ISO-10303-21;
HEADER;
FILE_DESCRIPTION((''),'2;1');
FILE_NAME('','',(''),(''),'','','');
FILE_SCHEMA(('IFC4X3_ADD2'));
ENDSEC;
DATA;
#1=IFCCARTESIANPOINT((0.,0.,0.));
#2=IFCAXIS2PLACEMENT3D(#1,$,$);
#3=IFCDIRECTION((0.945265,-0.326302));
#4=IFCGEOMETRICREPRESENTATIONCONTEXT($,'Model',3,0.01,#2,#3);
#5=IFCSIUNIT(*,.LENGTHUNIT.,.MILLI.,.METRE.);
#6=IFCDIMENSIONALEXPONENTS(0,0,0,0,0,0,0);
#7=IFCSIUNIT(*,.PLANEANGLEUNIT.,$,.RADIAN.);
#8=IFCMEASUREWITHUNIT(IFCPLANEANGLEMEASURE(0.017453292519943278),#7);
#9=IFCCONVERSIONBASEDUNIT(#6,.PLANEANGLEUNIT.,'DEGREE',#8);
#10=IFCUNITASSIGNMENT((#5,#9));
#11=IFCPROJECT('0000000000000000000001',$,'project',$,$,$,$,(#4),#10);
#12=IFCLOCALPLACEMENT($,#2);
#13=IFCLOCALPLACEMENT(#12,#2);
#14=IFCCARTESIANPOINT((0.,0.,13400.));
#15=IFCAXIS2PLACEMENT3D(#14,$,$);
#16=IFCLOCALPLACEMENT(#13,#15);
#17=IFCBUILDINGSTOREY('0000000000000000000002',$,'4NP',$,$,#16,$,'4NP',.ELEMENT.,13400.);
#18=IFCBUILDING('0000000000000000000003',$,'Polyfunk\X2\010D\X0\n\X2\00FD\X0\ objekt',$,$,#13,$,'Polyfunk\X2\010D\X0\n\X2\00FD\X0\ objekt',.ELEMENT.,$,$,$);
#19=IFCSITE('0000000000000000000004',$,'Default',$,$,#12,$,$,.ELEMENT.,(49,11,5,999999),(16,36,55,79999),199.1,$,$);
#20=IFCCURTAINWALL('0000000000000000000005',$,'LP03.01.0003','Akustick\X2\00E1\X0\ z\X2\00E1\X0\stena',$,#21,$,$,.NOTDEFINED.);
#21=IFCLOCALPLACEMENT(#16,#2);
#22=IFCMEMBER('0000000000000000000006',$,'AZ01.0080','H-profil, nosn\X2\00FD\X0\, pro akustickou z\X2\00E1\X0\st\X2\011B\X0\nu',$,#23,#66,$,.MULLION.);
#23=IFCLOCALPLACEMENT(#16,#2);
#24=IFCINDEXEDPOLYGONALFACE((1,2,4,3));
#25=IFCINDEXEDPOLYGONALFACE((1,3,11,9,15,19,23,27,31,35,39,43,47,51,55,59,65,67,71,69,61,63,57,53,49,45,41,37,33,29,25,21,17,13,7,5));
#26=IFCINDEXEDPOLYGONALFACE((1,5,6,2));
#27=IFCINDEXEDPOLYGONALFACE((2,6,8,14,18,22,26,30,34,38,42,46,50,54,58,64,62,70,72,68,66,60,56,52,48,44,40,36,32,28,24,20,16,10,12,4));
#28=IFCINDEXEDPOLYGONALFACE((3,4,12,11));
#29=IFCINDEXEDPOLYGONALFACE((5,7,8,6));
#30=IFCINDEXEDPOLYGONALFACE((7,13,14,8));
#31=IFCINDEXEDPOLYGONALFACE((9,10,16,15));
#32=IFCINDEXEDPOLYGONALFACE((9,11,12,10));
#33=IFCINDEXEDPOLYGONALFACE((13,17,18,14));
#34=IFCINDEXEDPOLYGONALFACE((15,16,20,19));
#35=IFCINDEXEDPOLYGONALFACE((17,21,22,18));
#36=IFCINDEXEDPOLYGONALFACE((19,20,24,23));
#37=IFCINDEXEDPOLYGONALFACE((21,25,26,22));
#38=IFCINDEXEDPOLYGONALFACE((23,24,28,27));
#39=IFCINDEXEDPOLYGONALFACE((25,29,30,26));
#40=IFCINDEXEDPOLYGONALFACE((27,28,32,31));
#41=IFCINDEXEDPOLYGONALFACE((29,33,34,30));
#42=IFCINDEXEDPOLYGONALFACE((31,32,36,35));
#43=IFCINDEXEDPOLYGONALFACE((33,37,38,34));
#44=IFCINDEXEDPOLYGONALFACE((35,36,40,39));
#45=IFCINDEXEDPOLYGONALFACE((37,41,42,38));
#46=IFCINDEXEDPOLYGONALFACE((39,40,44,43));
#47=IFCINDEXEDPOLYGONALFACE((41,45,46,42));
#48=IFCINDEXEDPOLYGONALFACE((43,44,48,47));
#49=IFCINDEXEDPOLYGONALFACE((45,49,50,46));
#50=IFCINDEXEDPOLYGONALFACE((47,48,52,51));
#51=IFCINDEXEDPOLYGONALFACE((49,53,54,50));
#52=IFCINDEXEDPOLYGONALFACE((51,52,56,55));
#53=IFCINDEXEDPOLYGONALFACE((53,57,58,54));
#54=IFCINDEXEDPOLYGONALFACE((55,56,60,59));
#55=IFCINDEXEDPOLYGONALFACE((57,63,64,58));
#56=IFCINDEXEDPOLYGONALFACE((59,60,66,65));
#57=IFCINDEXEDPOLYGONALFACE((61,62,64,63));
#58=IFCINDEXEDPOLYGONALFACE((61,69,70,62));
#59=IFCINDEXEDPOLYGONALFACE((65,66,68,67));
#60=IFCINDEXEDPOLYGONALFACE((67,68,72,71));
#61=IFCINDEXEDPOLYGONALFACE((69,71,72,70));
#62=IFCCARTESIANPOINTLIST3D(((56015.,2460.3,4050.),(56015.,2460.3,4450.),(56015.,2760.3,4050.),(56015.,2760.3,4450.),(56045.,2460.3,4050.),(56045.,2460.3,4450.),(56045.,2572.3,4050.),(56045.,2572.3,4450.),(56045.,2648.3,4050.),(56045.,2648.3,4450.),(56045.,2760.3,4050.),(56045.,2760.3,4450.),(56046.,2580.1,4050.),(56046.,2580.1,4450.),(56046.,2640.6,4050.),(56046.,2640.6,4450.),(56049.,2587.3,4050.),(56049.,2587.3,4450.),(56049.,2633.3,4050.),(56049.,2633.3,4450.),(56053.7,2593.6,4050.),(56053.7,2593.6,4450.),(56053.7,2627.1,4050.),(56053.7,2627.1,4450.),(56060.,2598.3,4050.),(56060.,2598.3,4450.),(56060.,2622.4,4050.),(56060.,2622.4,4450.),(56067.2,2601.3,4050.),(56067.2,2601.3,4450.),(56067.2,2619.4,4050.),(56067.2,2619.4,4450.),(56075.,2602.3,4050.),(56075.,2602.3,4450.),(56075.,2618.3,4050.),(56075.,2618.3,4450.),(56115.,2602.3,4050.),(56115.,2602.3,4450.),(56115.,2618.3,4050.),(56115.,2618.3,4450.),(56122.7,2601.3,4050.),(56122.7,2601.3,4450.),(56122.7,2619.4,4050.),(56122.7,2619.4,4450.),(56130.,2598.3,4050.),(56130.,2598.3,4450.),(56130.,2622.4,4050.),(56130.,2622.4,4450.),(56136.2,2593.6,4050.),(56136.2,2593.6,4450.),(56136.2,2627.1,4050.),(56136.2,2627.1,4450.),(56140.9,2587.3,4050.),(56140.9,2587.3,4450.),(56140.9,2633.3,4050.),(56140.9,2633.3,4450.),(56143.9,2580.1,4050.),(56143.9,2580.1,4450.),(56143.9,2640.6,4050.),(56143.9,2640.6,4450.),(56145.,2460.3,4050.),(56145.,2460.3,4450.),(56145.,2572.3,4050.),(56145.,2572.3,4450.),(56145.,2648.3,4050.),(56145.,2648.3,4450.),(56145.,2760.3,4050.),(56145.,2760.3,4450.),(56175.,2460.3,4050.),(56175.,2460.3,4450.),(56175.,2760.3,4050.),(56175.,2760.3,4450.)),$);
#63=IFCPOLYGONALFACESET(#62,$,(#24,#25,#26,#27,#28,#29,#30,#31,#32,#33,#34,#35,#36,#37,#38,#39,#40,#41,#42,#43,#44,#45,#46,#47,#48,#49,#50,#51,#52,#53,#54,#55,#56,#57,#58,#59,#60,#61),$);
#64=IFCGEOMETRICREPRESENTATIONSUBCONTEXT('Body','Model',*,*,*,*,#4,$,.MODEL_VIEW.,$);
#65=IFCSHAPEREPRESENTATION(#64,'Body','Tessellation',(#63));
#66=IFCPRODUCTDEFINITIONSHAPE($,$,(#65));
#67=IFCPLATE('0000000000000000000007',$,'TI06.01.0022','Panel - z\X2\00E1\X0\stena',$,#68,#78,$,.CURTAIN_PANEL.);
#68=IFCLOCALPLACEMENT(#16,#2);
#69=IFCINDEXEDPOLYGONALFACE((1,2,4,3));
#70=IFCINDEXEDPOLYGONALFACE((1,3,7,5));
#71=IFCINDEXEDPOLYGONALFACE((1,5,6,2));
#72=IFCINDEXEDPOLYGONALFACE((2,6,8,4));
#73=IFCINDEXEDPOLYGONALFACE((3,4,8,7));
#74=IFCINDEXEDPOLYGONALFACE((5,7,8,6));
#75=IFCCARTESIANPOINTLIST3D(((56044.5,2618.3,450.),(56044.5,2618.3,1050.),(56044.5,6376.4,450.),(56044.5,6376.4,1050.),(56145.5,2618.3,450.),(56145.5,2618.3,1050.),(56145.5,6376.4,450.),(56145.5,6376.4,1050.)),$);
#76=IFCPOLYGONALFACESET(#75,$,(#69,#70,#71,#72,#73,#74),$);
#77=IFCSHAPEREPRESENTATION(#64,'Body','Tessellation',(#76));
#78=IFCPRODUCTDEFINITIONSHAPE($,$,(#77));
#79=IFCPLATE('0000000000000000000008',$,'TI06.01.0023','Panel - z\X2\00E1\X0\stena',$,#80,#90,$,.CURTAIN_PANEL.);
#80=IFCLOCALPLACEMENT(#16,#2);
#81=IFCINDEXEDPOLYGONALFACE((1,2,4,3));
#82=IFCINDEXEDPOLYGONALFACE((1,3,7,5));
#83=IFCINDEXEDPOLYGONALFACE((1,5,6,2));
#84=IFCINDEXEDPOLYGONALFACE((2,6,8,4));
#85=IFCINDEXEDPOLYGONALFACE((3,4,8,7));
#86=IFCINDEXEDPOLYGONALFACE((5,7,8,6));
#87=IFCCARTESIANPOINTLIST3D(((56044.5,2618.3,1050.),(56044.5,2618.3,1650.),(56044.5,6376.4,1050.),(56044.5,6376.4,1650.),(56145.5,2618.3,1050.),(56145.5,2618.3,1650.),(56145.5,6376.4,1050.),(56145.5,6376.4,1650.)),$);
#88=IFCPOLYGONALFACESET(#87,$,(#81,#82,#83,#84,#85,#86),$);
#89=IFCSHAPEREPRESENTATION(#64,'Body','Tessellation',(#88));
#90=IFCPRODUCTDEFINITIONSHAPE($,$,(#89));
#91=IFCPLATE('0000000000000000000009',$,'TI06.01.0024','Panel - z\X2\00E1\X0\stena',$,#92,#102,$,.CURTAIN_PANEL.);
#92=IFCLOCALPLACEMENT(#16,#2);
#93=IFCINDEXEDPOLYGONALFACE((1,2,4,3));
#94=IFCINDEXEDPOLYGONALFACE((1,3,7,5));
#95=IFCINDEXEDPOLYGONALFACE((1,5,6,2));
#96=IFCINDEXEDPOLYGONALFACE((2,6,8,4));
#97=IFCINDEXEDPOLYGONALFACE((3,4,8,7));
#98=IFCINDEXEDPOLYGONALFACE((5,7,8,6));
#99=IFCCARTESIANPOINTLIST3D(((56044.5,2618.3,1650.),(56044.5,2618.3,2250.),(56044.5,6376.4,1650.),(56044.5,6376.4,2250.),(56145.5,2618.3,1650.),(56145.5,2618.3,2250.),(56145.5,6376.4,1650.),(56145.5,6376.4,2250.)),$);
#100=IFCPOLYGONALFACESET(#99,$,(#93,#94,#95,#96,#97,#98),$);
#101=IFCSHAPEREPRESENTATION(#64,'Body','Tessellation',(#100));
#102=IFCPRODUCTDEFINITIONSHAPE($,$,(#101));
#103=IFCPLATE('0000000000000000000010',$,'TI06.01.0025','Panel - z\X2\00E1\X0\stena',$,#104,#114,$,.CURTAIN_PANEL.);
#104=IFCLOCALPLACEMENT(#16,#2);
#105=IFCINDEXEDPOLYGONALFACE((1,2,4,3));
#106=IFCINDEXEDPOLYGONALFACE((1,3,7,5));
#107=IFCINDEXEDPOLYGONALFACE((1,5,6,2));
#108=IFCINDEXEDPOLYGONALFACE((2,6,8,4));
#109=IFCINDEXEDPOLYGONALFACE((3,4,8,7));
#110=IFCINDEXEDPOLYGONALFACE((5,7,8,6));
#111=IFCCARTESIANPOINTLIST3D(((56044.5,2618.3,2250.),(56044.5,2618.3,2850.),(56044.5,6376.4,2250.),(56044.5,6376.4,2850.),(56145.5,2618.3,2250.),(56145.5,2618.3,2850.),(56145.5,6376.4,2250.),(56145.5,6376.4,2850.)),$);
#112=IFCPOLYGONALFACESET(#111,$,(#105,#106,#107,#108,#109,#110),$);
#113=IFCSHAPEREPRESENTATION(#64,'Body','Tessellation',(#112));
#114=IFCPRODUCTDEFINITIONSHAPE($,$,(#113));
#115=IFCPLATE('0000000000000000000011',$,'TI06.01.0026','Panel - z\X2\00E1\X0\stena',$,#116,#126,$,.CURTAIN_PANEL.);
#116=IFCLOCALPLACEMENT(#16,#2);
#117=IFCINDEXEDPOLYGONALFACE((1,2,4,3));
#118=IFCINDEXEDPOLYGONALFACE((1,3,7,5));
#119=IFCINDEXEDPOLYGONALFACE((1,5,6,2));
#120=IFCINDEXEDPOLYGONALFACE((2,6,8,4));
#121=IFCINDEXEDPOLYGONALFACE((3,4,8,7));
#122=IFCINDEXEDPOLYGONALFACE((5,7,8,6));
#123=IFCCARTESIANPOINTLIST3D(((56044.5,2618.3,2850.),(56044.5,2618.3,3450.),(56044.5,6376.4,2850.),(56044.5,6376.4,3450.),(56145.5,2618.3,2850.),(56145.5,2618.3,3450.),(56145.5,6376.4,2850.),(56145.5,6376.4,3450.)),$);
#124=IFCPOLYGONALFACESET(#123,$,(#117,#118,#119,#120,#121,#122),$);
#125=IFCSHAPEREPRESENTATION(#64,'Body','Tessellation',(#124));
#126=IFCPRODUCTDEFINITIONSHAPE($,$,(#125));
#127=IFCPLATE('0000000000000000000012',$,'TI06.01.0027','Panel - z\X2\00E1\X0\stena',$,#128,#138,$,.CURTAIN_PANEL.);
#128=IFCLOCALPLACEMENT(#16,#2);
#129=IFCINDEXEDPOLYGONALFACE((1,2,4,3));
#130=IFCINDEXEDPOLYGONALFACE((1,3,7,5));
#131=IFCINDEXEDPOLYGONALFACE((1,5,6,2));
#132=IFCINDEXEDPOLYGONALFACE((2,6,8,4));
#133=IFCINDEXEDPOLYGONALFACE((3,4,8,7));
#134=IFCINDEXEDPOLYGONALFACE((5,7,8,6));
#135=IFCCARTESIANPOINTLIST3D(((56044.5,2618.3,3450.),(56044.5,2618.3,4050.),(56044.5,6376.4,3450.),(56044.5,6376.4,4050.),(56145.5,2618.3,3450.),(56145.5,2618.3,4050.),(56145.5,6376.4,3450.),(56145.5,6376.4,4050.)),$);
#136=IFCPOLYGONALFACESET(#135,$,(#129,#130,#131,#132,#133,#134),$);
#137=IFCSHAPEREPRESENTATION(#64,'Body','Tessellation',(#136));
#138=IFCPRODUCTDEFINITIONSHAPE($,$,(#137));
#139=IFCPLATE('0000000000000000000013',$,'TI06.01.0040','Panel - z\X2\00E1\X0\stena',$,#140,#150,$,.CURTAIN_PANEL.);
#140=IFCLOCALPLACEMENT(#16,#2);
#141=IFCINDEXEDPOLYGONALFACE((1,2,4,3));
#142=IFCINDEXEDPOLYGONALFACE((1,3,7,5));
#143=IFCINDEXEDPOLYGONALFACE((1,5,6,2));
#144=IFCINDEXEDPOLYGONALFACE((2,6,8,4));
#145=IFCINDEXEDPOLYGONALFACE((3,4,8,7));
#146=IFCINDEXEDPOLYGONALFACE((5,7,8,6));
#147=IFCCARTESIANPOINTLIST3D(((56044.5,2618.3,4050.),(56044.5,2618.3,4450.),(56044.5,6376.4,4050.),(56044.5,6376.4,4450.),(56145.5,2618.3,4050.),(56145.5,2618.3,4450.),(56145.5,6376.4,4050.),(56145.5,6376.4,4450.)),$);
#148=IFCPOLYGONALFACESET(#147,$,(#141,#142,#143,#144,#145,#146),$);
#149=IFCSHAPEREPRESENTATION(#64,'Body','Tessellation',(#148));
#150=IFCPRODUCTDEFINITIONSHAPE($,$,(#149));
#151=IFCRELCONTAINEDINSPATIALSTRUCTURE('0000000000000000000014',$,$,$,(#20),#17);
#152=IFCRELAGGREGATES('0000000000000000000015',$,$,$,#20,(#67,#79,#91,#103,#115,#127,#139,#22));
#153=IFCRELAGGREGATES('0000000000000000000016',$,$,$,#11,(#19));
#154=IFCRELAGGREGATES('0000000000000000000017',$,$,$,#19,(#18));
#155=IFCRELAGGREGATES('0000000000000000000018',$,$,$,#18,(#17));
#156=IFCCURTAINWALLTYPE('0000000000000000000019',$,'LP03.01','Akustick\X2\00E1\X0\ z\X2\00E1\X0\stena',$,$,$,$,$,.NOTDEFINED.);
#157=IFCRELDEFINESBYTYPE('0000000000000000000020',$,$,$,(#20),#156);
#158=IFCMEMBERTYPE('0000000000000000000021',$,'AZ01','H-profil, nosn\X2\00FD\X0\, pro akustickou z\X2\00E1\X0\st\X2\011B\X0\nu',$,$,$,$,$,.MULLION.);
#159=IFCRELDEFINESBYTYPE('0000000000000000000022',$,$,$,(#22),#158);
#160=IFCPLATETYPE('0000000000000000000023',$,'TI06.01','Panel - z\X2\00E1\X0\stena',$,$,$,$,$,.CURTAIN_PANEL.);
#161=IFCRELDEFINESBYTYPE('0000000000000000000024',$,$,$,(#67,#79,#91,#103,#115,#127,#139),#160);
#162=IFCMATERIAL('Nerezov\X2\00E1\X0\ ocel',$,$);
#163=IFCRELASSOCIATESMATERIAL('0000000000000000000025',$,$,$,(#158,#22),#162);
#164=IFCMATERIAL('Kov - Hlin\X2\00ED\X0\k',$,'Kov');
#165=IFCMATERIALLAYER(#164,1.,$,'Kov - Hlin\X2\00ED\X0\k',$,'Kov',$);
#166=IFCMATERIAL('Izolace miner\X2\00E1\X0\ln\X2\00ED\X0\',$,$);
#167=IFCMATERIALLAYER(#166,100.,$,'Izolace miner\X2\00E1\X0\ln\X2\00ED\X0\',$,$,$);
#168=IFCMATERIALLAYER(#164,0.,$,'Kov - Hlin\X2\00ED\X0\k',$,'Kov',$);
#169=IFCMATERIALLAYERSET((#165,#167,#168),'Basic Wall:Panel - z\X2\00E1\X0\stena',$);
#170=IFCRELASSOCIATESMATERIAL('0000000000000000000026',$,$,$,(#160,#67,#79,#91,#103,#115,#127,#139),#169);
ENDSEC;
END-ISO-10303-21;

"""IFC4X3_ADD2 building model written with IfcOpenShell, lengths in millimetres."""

from ifc_helpers import new_model, entity, si_unit, converted_unit, direction, frame, frame_2d, origin, place, context, subcontext, project, spatial, polyline, circle_curve, parameter, trimmed, segment, composite_curve, rectangle, outline, extrude, source, transform, mapped, material, layer, layer_set, layer_usage, material_profile, profile_set, profile_usage, type_object, element, aggregate, save


model = new_model("IFC4X3_ADD2")

# Units and contexts
model_context = context("Model", 3, precision=0.01, world=origin(), true_north=direction((0.945265, -0.326302)))
body_context = subcontext(model_context, "Body", "Model", "MODEL_VIEW")
ifc_project = project(units=[si_unit("LENGTHUNIT", "METRE", prefix="MILLI"), converted_unit("PLANEANGLEUNIT", "DEGREE", entity("IfcPlaneAngleMeasure", 0.017453292519943278), si_unit("PLANEANGLEUNIT", "RADIAN"), dimensions=[0, 0, 0, 0, 0, 0, 0])], contexts=[model_context])

# Site, building, storey
site_placement = place(None, origin())
site = spatial("IfcSite", under=ifc_project, at=site_placement, Name="Default", CompositionType="ELEMENT", RefLatitude=(49, 11, 5, 999999), RefLongitude=(16, 36, 55, 79999), RefElevation=199.1)
building_placement = place(site_placement, origin())
building = spatial("IfcBuilding", under=site, at=building_placement, Name="Polyfunkčný objekt", LongName="Polyfunkčný objekt", CompositionType="ELEMENT")
storey_placement = place(building_placement, frame((0.0, 0.0, 13400.0)))
storey = spatial("IfcBuildingStorey", under=building, at=storey_placement, Name="4NP", LongName="4NP", CompositionType="ELEMENT", Elevation=13400.0)

# Shared definitions
curtain_wall_type = type_object("IfcCurtainWallType", Name="LP03.01", Description="Akustická zástena", PredefinedType="NOTDEFINED")
ifc_material_1 = material(Name="Nerezová ocel")
ifc_material_profile = material_profile(ifc_material_1, outline(composite_curve([segment(polyline([(50.0, -150.0), (80.0, -150.0)]), True, "CONTINUOUS"), segment(polyline([(80.0, -150.0), (80.0, 150.0)]), True, "CONTINUOUS"), segment(polyline([(80.0, 150.0), (50.0, 150.0)]), True, "CONTINUOUS"), segment(polyline([(50.0, 150.0), (50.0, 38.0)]), True, "CONTINUOUS"), segment(trimmed(circle_curve(frame_2d((20.0, 38.0), x_axis=(0.0, 1.0)), 30.0), [parameter(180.0)], [parameter(270.0)], True, "PARAMETER"), False, "CONTINUOUS"), segment(polyline([(20.0, 8.0), (-20.0, 8.0)]), True, "CONTINUOUS"), segment(trimmed(circle_curve(frame_2d((-20.0, 38.0), x_axis=(0.0, 1.0)), 30.0), [parameter(90.0)], [parameter(180.0)], True, "PARAMETER"), False, "CONTINUOUS"), segment(polyline([(-50.0, 38.0), (-50.0, 150.0)]), True, "CONTINUOUS"), segment(polyline([(-50.0, 150.0), (-80.0, 150.0)]), True, "CONTINUOUS"), segment(polyline([(-80.0, 150.0), (-80.0, -150.0)]), True, "CONTINUOUS"), segment(polyline([(-80.0, -150.0), (-50.0, -150.0)]), True, "CONTINUOUS"), segment(polyline([(-50.0, -150.0), (-50.0, -38.0)]), True, "CONTINUOUS"), segment(trimmed(circle_curve(frame_2d((-20.0, -38.0), x_axis=(0.0, 1.0)), 30.0), [parameter(0.0)], [parameter(90.0)], True, "PARAMETER"), False, "CONTINUOUS"), segment(polyline([(-20.0, -8.0), (20.0, -8.0)]), True, "CONTINUOUS"), segment(trimmed(circle_curve(frame_2d((20.0, -38.0), x_axis=(0.0, 1.0)), 30.0), [parameter(270.0)], [parameter(0.0)], True, "PARAMETER"), False, "CONTINUOUS"), segment(polyline([(50.0, -38.0), (50.0, -150.0)]), True, "CONTINUOUS")], self_intersect=False)), Name="Profil zástena")
ifc_profile_set = profile_set([ifc_material_profile], Name="Profil zástena")
ifc_profile_usage = profile_usage(ifc_profile_set)
member_type = type_object("IfcMemberType", Name="AZ01", Description="H-profil, nosný, pro akustickou zástěnu", PredefinedType="MULLION", material=ifc_profile_set)

# Curtain wall, member, plates
curtain_wall_1_placement = place(storey_placement, frame((0.0, 0.0, -13400.0)))
curtain_wall_1 = element("IfcCurtainWall", 1, at=curtain_wall_1_placement, inside=storey, type_object=curtain_wall_type, Name="LP03.01.0003", Description="Akustická zástena", PredefinedType="NOTDEFINED")
shared_shape_1 = source(origin(), body_context, "Body", "SweptSolid", [
    extrude(outline(composite_curve([segment(polyline([(-150.0, -50.0), (-150.0, -80.0)]), True, "CONTINUOUS"), segment(polyline([(-150.0, -80.0), (150.0, -80.0)]), True, "CONTINUOUS"), segment(polyline([(150.0, -80.0), (150.0, -50.0)]), True, "CONTINUOUS"), segment(polyline([(150.0, -50.0), (38.0, -50.0)]), True, "CONTINUOUS"), segment(trimmed(circle_curve(frame_2d((38.0, -20.0), x_axis=(1.0, 0.0)), 30.0), [parameter(180.0)], [parameter(270.0)], True, "PARAMETER"), False, "CONTINUOUS"), segment(polyline([(8.0, -20.0), (8.0, 20.0)]), True, "CONTINUOUS"), segment(trimmed(circle_curve(frame_2d((38.0, 20.0), x_axis=(1.0, 0.0)), 30.0), [parameter(90.0)], [parameter(180.0)], True, "PARAMETER"), False, "CONTINUOUS"), segment(polyline([(38.0, 50.0), (150.0, 50.0)]), True, "CONTINUOUS"), segment(polyline([(150.0, 50.0), (150.0, 80.0)]), True, "CONTINUOUS"), segment(polyline([(150.0, 80.0), (-150.0, 80.0)]), True, "CONTINUOUS"), segment(polyline([(-150.0, 80.0), (-150.0, 50.0)]), True, "CONTINUOUS"), segment(polyline([(-150.0, 50.0), (-38.0, 50.0)]), True, "CONTINUOUS"), segment(trimmed(circle_curve(frame_2d((-38.0, 20.0), x_axis=(1.0, 0.0)), 30.0), [parameter(0.0)], [parameter(90.0)], True, "PARAMETER"), False, "CONTINUOUS"), segment(polyline([(-8.0, 20.0), (-8.0, -20.0)]), True, "CONTINUOUS"), segment(trimmed(circle_curve(frame_2d((-38.0, -20.0), x_axis=(1.0, 0.0)), 30.0), [parameter(270.0)], [parameter(360.0)], True, "PARAMETER"), False, "CONTINUOUS"), segment(polyline([(-38.0, -50.0), (-150.0, -50.0)]), True, "CONTINUOUS")], self_intersect=False)), frame((0.0, 0.0, -400.0), z_axis=(0.0, 0.0, -1.0), x_axis=(1.0, 0.0, 0.0)), (0.0, 0.0, -1.0), 400.0),
])
member_1_placement = place(curtain_wall_1_placement, frame((56095.0, 2610.3, 17450.0), z_axis=(0.0, 0.0, -1.0), x_axis=(0.0, 1.0, 0.0)))
member_1 = element("IfcMember", 2, at=member_1_placement, type_object=member_type, material=ifc_profile_usage, Name="AZ01.0080", Description="H-profil, nosný, pro akustickou zástěnu", PredefinedType="MULLION", context=body_context, shape_type="MappedRepresentation", body=[
    mapped(shared_shape_1, transform((0.0, 0.0, 0.0), scale=1.0)),
])
ifc_material_2 = material(Name="Kov - Hliník", Category="Kov")
ifc_layer_1 = layer(ifc_material_2, 1.0, Name="Kov - Hliník", Category="Kov")
ifc_material_3 = material(Name="Izolace minerální")
ifc_layer_2 = layer(ifc_material_3, 100.0, Name="Izolace minerální")
ifc_layer_3 = layer(ifc_material_2, 0.0, Name="Kov - Hliník", Category="Kov")
ifc_layer_set = layer_set([ifc_layer_1, ifc_layer_2, ifc_layer_3], Name="Basic Wall:Panel - zástena")
ifc_layer_usage_1 = layer_usage(ifc_layer_set, "AXIS2", "NEGATIVE", 50.5)
plate_type = type_object("IfcPlateType", Name="TI06.01", Description="Panel - zástena", PredefinedType="CURTAIN_PANEL", material=ifc_layer_set)
plate_1_placement = place(storey_placement, frame((56095.0, 2618.3, 450.0), z_axis=(0.0, 0.0, 1.0), x_axis=(0.0, 1.0, 0.0)))
plate_1 = element("IfcPlate", 3, at=plate_1_placement, type_object=plate_type, material=ifc_layer_usage_1, Name="TI06.01.0022", Description="Panel - zástena", PredefinedType="CURTAIN_PANEL", context=body_context, shape_type="SweptSolid", body=[
    extrude(rectangle(XDim=101.0, YDim=3758.1, at=frame_2d((0.0, 0.0), x_axis=(1.0, 0.0))), frame((1879.0, 0.0, 0.0), z_axis=(0.0, 0.0, 1.0), x_axis=(0.0, 1.0, 0.0)), (0.0, 0.0, 1.0), 600.0),
])
ifc_layer_usage_2 = layer_usage(ifc_layer_set, "AXIS2", "NEGATIVE", 50.5)
plate_2_placement = place(storey_placement, frame((56095.0, 2618.3, 1050.0), z_axis=(0.0, 0.0, 1.0), x_axis=(0.0, 1.0, 0.0)))
plate_2 = element("IfcPlate", 4, at=plate_2_placement, type_object=plate_type, material=ifc_layer_usage_2, Name="TI06.01.0023", Description="Panel - zástena", PredefinedType="CURTAIN_PANEL", context=body_context, shape_type="SweptSolid", body=[
    extrude(rectangle(XDim=101.0, YDim=3758.1, at=frame_2d((0.0, 0.0), x_axis=(1.0, 0.0))), frame((1879.0, 0.0, 0.0), z_axis=(0.0, 0.0, 1.0), x_axis=(0.0, 1.0, 0.0)), (0.0, 0.0, 1.0), 600.0),
])
ifc_layer_usage_3 = layer_usage(ifc_layer_set, "AXIS2", "NEGATIVE", 50.5)
plate_3_placement = place(storey_placement, frame((56095.0, 2618.3, 1650.0), z_axis=(0.0, 0.0, 1.0), x_axis=(0.0, 1.0, 0.0)))
plate_3 = element("IfcPlate", 5, at=plate_3_placement, type_object=plate_type, material=ifc_layer_usage_3, Name="TI06.01.0024", Description="Panel - zástena", PredefinedType="CURTAIN_PANEL", context=body_context, shape_type="SweptSolid", body=[
    extrude(rectangle(XDim=101.0, YDim=3758.1, at=frame_2d((0.0, 0.0), x_axis=(1.0, 0.0))), frame((1879.0, 0.0, 0.0), z_axis=(0.0, 0.0, 1.0), x_axis=(0.0, 1.0, 0.0)), (0.0, 0.0, 1.0), 600.0),
])
ifc_layer_usage_4 = layer_usage(ifc_layer_set, "AXIS2", "NEGATIVE", 50.5)
plate_4_placement = place(storey_placement, frame((56095.0, 2618.3, 2250.0), z_axis=(0.0, 0.0, 1.0), x_axis=(0.0, 1.0, 0.0)))
plate_4 = element("IfcPlate", 6, at=plate_4_placement, type_object=plate_type, material=ifc_layer_usage_4, Name="TI06.01.0025", Description="Panel - zástena", PredefinedType="CURTAIN_PANEL", context=body_context, shape_type="SweptSolid", body=[
    extrude(rectangle(XDim=101.0, YDim=3758.1, at=frame_2d((0.0, 0.0), x_axis=(1.0, 0.0))), frame((1879.0, 0.0, 0.0), z_axis=(0.0, 0.0, 1.0), x_axis=(0.0, 1.0, 0.0)), (0.0, 0.0, 1.0), 600.0),
])
ifc_layer_usage_5 = layer_usage(ifc_layer_set, "AXIS2", "NEGATIVE", 50.5)
plate_5_placement = place(storey_placement, frame((56095.0, 2618.3, 2850.0), z_axis=(0.0, 0.0, 1.0), x_axis=(0.0, 1.0, 0.0)))
plate_5 = element("IfcPlate", 7, at=plate_5_placement, type_object=plate_type, material=ifc_layer_usage_5, Name="TI06.01.0026", Description="Panel - zástena", PredefinedType="CURTAIN_PANEL", context=body_context, shape_type="SweptSolid", body=[
    extrude(rectangle(XDim=101.0, YDim=3758.1, at=frame_2d((0.0, 0.0), x_axis=(1.0, 0.0))), frame((1879.0, 0.0, 0.0), z_axis=(0.0, 0.0, 1.0), x_axis=(0.0, 1.0, 0.0)), (0.0, 0.0, 1.0), 600.0),
])
ifc_layer_usage_6 = layer_usage(ifc_layer_set, "AXIS2", "NEGATIVE", 50.5)
plate_6_placement = place(storey_placement, frame((56095.0, 2618.3, 3450.0), z_axis=(0.0, 0.0, 1.0), x_axis=(0.0, 1.0, 0.0)))
plate_6 = element("IfcPlate", 8, at=plate_6_placement, type_object=plate_type, material=ifc_layer_usage_6, Name="TI06.01.0027", Description="Panel - zástena", PredefinedType="CURTAIN_PANEL", context=body_context, shape_type="SweptSolid", body=[
    extrude(rectangle(XDim=101.0, YDim=3758.1, at=frame_2d((0.0, 0.0), x_axis=(1.0, 0.0))), frame((1879.0, 0.0, 0.0), z_axis=(0.0, 0.0, 1.0), x_axis=(0.0, 1.0, 0.0)), (0.0, 0.0, 1.0), 600.0),
])
ifc_layer_usage_7 = layer_usage(ifc_layer_set, "AXIS2", "NEGATIVE", 50.5)
plate_7_placement = place(storey_placement, frame((56095.0, 2618.3, 4050.0), z_axis=(0.0, 0.0, 1.0), x_axis=(0.0, 1.0, 0.0)))
plate_7 = element("IfcPlate", 9, at=plate_7_placement, type_object=plate_type, material=ifc_layer_usage_7, Name="TI06.01.0040", Description="Panel - zástena", PredefinedType="CURTAIN_PANEL", context=body_context, shape_type="SweptSolid", body=[
    extrude(rectangle(XDim=101.0, YDim=3758.1, at=frame_2d((0.0, 0.0), x_axis=(1.0, 0.0))), frame((1879.0, 0.0, 0.0), z_axis=(0.0, 0.0, 1.0), x_axis=(0.0, 1.0, 0.0)), (0.0, 0.0, 1.0), 400.0),
])
aggregate(curtain_wall_1, [plate_1, plate_2, plate_3, plate_4, plate_5, plate_6, plate_7, member_1])

save(model, "model.ifc")
